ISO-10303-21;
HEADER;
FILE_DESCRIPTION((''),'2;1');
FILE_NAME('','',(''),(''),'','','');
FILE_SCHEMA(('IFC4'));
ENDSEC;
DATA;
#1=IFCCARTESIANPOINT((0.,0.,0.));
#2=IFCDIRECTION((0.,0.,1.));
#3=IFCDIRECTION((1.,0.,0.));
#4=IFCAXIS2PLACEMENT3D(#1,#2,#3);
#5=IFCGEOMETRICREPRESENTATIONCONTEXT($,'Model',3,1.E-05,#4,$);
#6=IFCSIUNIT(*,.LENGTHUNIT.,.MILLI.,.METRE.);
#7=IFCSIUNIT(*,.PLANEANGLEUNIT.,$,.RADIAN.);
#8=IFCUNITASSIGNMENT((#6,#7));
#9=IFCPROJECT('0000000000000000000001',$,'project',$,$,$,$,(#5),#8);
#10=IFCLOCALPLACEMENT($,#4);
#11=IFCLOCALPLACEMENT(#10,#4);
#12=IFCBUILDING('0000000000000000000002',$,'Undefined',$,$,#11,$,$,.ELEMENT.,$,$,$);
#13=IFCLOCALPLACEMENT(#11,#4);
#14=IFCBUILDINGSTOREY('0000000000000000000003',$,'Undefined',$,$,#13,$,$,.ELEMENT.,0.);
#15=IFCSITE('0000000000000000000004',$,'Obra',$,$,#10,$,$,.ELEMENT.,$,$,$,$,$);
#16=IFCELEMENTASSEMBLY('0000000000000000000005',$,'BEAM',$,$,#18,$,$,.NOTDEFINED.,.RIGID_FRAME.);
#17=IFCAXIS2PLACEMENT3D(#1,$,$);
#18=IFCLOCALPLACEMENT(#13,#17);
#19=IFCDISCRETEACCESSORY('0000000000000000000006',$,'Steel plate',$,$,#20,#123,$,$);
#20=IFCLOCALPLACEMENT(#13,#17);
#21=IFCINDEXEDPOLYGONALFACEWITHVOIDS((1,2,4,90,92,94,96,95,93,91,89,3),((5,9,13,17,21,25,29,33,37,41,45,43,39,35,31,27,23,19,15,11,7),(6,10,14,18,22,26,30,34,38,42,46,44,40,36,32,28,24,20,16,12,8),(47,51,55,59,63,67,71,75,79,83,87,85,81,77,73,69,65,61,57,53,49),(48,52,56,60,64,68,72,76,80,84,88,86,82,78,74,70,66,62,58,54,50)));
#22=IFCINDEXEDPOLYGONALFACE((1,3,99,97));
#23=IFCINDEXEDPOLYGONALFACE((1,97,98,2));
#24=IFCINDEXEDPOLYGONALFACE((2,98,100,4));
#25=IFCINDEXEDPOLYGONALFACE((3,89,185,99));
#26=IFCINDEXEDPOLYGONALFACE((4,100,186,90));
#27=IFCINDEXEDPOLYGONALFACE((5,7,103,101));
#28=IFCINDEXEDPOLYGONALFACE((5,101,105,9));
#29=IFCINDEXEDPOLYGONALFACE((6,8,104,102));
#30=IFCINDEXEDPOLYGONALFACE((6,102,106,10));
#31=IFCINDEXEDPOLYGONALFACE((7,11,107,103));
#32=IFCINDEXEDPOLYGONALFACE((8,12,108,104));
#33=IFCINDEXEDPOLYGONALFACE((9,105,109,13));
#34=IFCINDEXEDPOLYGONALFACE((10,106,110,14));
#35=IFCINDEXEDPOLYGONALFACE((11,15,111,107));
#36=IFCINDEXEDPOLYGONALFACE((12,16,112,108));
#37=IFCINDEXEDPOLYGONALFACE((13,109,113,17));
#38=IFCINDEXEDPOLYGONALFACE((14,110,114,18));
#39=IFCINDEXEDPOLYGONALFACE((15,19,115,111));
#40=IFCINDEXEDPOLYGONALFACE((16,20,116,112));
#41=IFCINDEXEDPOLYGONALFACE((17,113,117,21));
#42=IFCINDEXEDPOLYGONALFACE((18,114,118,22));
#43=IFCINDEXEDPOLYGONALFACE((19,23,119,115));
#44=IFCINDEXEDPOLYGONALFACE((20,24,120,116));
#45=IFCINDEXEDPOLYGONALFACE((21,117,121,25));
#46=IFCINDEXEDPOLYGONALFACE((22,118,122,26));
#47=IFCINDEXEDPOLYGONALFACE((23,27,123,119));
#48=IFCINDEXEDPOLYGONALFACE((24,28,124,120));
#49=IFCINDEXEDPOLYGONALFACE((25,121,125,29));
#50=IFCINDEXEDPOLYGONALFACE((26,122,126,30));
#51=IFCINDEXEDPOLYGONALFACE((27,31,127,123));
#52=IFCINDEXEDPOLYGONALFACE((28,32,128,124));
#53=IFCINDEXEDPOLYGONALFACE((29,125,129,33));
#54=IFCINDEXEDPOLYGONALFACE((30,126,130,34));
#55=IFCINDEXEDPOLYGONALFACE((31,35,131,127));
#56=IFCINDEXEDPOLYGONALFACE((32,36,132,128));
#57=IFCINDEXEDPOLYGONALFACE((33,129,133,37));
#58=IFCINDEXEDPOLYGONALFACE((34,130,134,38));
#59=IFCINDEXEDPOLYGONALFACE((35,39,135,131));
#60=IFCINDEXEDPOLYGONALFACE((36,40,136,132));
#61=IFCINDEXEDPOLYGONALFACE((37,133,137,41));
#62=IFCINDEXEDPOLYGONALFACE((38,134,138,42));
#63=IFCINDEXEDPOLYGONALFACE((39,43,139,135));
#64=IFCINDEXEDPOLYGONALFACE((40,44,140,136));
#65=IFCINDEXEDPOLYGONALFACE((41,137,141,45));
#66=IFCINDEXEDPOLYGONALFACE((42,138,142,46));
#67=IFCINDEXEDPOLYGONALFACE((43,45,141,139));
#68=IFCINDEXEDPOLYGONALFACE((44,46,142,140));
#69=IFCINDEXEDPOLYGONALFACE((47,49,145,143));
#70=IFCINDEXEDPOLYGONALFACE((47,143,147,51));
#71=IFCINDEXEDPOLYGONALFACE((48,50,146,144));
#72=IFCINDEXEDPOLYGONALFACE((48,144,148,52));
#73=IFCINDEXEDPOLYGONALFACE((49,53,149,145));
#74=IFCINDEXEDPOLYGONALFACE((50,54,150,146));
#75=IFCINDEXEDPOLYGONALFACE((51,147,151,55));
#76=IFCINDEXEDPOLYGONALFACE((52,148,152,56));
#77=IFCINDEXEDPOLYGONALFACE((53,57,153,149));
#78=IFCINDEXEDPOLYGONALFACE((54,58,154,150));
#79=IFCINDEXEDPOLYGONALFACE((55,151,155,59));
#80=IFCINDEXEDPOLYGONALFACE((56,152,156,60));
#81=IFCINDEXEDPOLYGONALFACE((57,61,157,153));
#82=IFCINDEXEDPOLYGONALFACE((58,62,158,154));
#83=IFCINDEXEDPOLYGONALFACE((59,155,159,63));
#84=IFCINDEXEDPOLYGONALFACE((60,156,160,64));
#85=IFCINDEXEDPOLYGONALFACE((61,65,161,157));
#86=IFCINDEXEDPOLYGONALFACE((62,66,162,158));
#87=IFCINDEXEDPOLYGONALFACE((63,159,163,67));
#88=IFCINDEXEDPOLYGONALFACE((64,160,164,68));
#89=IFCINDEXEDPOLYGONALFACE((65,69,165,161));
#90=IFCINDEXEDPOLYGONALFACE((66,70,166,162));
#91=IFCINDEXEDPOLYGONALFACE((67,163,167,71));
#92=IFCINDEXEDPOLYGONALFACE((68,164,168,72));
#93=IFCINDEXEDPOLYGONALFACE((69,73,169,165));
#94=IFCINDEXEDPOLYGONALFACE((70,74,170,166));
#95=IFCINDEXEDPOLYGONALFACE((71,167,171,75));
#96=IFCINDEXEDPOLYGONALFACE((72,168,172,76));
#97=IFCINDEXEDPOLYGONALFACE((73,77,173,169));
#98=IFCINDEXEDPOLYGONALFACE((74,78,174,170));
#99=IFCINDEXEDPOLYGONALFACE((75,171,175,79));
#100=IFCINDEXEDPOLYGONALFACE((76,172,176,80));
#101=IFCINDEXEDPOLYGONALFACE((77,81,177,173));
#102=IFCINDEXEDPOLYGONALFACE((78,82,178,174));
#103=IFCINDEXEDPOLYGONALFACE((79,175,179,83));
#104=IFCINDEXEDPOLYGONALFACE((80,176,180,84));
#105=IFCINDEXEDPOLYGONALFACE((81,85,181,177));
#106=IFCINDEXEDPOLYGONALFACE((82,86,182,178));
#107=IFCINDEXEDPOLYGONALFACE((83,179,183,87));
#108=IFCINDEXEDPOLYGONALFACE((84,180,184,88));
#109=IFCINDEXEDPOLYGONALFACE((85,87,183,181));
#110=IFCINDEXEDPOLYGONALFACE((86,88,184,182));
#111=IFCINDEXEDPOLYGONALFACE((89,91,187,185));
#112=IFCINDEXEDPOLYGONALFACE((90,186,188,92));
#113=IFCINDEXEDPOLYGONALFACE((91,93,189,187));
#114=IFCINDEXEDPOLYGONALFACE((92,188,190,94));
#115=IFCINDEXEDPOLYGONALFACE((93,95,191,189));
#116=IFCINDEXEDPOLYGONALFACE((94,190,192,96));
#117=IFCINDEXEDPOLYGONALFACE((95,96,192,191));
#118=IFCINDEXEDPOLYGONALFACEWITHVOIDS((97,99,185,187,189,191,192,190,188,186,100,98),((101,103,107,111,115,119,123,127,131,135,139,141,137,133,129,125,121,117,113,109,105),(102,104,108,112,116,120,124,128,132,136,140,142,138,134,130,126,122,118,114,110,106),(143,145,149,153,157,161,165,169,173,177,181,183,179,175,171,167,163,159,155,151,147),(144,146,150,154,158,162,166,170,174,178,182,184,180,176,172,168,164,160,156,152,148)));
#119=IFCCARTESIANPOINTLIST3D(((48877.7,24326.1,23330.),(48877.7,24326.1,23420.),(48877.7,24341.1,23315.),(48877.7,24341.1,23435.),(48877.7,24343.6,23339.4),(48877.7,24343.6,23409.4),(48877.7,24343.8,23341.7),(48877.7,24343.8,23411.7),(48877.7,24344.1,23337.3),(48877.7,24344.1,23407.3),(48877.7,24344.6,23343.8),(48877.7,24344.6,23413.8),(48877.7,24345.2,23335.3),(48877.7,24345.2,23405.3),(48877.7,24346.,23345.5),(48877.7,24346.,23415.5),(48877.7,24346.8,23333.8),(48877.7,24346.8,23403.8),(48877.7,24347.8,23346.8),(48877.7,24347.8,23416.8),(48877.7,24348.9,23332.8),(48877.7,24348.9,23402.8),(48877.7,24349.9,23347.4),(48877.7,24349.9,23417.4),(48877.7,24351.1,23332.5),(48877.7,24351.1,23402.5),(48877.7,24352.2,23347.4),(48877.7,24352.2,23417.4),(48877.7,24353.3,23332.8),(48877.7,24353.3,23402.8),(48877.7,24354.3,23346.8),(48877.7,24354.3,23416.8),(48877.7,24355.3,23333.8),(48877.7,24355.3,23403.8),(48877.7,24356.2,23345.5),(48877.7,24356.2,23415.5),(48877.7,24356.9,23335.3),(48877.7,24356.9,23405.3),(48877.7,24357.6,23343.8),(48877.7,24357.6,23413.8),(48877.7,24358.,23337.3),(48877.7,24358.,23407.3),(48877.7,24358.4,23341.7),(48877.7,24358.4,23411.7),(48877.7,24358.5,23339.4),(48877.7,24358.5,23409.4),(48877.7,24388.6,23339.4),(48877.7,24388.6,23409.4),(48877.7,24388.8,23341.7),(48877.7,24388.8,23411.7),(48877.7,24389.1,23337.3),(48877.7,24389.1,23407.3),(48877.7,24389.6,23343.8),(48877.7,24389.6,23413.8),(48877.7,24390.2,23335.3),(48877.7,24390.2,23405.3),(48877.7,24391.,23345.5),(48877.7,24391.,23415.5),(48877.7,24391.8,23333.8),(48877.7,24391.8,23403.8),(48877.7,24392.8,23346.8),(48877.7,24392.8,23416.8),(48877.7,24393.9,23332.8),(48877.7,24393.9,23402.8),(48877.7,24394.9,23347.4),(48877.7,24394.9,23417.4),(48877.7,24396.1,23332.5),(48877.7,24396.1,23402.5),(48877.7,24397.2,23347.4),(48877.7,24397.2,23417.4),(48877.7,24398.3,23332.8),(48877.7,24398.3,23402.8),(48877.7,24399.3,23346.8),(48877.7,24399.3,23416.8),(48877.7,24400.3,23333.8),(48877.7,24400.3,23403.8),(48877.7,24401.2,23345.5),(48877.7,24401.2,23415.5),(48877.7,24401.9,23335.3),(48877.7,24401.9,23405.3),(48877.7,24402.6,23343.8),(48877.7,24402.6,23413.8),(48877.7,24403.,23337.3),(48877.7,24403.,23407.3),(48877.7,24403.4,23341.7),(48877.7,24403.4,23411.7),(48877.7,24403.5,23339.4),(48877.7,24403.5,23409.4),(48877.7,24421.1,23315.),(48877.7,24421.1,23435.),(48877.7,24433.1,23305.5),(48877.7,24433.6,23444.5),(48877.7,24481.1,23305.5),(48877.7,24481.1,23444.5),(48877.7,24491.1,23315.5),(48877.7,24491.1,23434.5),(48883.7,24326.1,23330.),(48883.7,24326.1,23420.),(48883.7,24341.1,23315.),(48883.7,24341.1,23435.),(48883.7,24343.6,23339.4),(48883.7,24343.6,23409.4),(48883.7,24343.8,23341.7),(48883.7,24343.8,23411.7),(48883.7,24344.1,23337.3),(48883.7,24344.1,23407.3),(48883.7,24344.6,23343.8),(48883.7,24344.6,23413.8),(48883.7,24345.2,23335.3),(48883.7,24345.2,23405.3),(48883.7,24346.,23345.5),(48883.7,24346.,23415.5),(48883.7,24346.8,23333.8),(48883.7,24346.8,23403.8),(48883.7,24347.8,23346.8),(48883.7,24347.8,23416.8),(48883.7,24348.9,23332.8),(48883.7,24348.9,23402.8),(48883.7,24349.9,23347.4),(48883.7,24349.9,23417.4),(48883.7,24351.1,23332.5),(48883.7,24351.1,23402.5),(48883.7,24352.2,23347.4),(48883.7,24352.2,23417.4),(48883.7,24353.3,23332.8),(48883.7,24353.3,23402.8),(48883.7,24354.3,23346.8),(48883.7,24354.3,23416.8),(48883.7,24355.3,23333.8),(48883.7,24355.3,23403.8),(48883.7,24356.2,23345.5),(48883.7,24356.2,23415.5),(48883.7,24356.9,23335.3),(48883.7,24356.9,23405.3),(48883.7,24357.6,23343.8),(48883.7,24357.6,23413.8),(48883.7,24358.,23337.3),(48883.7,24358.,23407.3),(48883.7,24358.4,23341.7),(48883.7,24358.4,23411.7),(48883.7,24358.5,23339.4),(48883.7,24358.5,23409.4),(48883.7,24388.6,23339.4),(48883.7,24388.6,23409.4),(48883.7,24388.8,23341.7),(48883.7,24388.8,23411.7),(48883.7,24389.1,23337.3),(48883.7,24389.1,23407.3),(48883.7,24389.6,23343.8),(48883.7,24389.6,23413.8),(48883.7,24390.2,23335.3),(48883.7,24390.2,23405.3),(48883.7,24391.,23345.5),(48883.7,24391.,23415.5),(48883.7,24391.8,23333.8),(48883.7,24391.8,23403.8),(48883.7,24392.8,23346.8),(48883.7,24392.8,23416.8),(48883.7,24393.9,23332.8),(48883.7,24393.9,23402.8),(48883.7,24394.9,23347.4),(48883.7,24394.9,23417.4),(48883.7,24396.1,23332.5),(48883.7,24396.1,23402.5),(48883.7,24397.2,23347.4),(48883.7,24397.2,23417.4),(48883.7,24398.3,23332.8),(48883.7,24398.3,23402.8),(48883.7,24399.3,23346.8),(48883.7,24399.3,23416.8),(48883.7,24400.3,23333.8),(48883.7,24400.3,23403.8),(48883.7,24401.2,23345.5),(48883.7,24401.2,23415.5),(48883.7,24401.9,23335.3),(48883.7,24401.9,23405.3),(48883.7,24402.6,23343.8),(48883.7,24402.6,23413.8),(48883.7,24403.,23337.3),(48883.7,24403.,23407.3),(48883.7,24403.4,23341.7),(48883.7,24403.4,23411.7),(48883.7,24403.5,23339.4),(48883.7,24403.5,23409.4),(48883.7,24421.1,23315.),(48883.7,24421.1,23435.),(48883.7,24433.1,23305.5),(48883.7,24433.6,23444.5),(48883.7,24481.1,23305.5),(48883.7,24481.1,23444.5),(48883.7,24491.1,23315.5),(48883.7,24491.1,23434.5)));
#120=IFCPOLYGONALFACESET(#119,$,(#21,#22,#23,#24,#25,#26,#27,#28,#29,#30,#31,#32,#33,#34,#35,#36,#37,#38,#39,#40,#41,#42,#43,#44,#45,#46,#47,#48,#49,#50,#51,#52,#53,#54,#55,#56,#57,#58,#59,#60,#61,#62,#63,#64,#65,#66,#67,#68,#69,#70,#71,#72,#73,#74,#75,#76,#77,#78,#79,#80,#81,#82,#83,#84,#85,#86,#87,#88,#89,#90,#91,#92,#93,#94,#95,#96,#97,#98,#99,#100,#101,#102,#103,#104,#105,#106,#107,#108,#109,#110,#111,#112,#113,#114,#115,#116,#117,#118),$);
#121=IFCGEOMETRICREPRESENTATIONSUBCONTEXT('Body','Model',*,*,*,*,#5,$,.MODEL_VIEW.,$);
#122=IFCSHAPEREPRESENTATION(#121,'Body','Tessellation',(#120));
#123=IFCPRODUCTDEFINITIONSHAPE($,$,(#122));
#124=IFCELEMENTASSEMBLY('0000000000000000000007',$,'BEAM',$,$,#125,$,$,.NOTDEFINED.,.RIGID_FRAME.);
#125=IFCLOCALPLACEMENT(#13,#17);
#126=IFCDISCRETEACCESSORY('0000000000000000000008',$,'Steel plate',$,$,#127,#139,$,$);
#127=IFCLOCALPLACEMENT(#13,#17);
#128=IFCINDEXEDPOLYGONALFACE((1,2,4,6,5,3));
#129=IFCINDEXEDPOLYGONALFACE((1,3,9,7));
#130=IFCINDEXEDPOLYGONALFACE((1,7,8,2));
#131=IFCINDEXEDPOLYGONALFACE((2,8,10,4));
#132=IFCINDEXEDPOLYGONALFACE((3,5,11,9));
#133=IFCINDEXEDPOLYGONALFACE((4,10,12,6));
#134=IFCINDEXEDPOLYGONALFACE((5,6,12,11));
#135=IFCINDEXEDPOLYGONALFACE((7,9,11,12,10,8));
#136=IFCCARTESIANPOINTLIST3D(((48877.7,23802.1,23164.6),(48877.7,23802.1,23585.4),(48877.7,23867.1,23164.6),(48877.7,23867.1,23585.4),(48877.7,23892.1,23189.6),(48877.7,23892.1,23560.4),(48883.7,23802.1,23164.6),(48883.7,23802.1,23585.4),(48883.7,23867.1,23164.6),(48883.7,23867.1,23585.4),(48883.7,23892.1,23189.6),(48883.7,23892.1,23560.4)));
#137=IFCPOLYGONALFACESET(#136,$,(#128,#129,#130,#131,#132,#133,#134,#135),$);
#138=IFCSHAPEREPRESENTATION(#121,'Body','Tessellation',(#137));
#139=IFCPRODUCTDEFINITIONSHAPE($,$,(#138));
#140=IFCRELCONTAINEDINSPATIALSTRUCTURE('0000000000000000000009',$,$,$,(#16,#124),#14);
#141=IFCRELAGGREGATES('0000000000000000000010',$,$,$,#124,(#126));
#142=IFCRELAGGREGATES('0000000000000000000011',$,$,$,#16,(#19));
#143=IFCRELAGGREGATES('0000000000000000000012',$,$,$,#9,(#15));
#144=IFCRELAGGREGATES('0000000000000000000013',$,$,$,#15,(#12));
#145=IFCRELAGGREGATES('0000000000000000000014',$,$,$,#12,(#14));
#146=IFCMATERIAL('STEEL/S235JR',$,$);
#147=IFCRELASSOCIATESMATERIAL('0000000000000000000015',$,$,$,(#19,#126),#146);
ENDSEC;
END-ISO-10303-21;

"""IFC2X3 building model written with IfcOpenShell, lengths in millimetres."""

from ifc_helpers import new_model, si_unit, frame, origin_with_axes, origin_2d_with_axis, place, context, subcontext, project, spatial, polyline, circle, outline, extrude, source, transform, mapped, material, element, aggregate, save


model = new_model("IFC2X3")

# Units and contexts
model_context = context("Model", 3, precision=1e-05, world=origin_with_axes())
body_context = subcontext(model_context, "Body", "Model", "MODEL_VIEW")
ifc_project = project(units=[si_unit("LENGTHUNIT", "METRE", prefix="MILLI"), si_unit("PLANEANGLEUNIT", "RADIAN")], contexts=[model_context])

# Site, building, storey
site_placement = place(None, origin_with_axes())
site = spatial("IfcSite", under=ifc_project, at=site_placement, Name="Obra", CompositionType="ELEMENT")
building_placement = place(site_placement, origin_with_axes())
building = spatial("IfcBuilding", under=site, at=building_placement, Name="Undefined", CompositionType="ELEMENT")
storey_placement = place(building_placement, origin_with_axes())
storey = spatial("IfcBuildingStorey", under=building, at=storey_placement, Name="Undefined", CompositionType="ELEMENT", Elevation=0.0)

# Shared definitions
ifc_material_1 = material(Name="STEEL/S235JR")

# Element assembly
assembly_1_placement = place(storey_placement, origin_with_axes())
assembly_1 = element("IfcElementAssembly", 1, at=assembly_1_placement, inside=storey, Name="BEAM", AssemblyPlace="NOTDEFINED", PredefinedType="RIGID_FRAME")

# Discrete accessory, opening
shared_shape_1 = source(origin_with_axes(), body_context, "Body", "SweptSolid", [
    extrude(circle(Radius=7.5, at=origin_2d_with_axis()), frame((0.0, 2.4, 0.0), z_axis=(0.0, 1.0, 0.0), x_axis=(1.0, 0.0, 0.0)), (0.0, 0.0, 1.0), 6.2),
])
discrete_accessory_1_placement = place(assembly_1_placement, frame((48880.7, 24491.1, 23315.5), z_axis=(-1.0, 0.0, 0.0), x_axis=(0.000001, -0.707107, -0.707107)))
discrete_accessory_1 = element("IfcDiscreteAccessory", 2, at=discrete_accessory_1_placement, material=ifc_material_1, Name="Steel plate", context=body_context, shape_type="SweptSolid", body=[
    extrude(outline(polyline([(0.0, 0.0), (14.1, 0.0), (48.1, 33.9), (49.9, 49.1), (106.4, 105.7), (106.4, 126.9), (42.8, 190.6), (21.6, 190.6), (-35.0, 134.0), (-50.6, 131.9), (-84.1, 98.3), (-84.1, 84.1), (0.0, 0.0)])), frame((0.0, 0.0, -3.0), z_axis=(0.0, 0.0, 1.0), x_axis=(1.0, 0.0, 0.0)), (0.0, 0.0, 1.0), 6.0),
])
opening_1_placement = place(assembly_1_placement, frame((48875.2, 24373.6, 23410.0), z_axis=(0.0, -1.0, 0.0), x_axis=(0.0, 0.0, -1.0)))
element("IfcOpeningElement", 3, at=opening_1_placement, cuts=discrete_accessory_1, ObjectType="Opening", context=body_context, shape_type="MappedRepresentation", body=[
    mapped(shared_shape_1, transform((0.0, 0.0, -22.5))),
    mapped(shared_shape_1, transform((70.0, 0.0, -22.5))),
    mapped(shared_shape_1, transform((0.0, 0.0, 22.5))),
    mapped(shared_shape_1, transform((70.0, 0.0, 22.5))),
])

# Element assembly, discrete accessory
assembly_2_placement = place(storey_placement, origin_with_axes())
assembly_2 = element("IfcElementAssembly", 4, at=assembly_2_placement, inside=storey, Name="BEAM", AssemblyPlace="NOTDEFINED", PredefinedType="RIGID_FRAME")
discrete_accessory_2_placement = place(assembly_2_placement, frame((48880.7, 23892.1, 23164.6), z_axis=(-1.0, 0.0, 0.0), x_axis=(0.0, -1.0, 0.0)))
discrete_accessory_2 = element("IfcDiscreteAccessory", 5, at=discrete_accessory_2_placement, material=ifc_material_1, Name="Steel plate", context=body_context, shape_type="SweptSolid", body=[
    extrude(outline(polyline([(0.0, 25.0), (25.0, 0.0), (90.0, 0.0), (90.0, 420.8), (25.0, 420.8), (0.0, 395.8), (0.0, 25.0)])), frame((0.0, 0.0, -3.0), z_axis=(0.0, 0.0, 1.0), x_axis=(1.0, 0.0, 0.0)), (0.0, 0.0, 1.0), 6.0),
])
aggregate(assembly_2, [discrete_accessory_2])

aggregate(assembly_1, [discrete_accessory_1])

save(model, "model.ifc")
